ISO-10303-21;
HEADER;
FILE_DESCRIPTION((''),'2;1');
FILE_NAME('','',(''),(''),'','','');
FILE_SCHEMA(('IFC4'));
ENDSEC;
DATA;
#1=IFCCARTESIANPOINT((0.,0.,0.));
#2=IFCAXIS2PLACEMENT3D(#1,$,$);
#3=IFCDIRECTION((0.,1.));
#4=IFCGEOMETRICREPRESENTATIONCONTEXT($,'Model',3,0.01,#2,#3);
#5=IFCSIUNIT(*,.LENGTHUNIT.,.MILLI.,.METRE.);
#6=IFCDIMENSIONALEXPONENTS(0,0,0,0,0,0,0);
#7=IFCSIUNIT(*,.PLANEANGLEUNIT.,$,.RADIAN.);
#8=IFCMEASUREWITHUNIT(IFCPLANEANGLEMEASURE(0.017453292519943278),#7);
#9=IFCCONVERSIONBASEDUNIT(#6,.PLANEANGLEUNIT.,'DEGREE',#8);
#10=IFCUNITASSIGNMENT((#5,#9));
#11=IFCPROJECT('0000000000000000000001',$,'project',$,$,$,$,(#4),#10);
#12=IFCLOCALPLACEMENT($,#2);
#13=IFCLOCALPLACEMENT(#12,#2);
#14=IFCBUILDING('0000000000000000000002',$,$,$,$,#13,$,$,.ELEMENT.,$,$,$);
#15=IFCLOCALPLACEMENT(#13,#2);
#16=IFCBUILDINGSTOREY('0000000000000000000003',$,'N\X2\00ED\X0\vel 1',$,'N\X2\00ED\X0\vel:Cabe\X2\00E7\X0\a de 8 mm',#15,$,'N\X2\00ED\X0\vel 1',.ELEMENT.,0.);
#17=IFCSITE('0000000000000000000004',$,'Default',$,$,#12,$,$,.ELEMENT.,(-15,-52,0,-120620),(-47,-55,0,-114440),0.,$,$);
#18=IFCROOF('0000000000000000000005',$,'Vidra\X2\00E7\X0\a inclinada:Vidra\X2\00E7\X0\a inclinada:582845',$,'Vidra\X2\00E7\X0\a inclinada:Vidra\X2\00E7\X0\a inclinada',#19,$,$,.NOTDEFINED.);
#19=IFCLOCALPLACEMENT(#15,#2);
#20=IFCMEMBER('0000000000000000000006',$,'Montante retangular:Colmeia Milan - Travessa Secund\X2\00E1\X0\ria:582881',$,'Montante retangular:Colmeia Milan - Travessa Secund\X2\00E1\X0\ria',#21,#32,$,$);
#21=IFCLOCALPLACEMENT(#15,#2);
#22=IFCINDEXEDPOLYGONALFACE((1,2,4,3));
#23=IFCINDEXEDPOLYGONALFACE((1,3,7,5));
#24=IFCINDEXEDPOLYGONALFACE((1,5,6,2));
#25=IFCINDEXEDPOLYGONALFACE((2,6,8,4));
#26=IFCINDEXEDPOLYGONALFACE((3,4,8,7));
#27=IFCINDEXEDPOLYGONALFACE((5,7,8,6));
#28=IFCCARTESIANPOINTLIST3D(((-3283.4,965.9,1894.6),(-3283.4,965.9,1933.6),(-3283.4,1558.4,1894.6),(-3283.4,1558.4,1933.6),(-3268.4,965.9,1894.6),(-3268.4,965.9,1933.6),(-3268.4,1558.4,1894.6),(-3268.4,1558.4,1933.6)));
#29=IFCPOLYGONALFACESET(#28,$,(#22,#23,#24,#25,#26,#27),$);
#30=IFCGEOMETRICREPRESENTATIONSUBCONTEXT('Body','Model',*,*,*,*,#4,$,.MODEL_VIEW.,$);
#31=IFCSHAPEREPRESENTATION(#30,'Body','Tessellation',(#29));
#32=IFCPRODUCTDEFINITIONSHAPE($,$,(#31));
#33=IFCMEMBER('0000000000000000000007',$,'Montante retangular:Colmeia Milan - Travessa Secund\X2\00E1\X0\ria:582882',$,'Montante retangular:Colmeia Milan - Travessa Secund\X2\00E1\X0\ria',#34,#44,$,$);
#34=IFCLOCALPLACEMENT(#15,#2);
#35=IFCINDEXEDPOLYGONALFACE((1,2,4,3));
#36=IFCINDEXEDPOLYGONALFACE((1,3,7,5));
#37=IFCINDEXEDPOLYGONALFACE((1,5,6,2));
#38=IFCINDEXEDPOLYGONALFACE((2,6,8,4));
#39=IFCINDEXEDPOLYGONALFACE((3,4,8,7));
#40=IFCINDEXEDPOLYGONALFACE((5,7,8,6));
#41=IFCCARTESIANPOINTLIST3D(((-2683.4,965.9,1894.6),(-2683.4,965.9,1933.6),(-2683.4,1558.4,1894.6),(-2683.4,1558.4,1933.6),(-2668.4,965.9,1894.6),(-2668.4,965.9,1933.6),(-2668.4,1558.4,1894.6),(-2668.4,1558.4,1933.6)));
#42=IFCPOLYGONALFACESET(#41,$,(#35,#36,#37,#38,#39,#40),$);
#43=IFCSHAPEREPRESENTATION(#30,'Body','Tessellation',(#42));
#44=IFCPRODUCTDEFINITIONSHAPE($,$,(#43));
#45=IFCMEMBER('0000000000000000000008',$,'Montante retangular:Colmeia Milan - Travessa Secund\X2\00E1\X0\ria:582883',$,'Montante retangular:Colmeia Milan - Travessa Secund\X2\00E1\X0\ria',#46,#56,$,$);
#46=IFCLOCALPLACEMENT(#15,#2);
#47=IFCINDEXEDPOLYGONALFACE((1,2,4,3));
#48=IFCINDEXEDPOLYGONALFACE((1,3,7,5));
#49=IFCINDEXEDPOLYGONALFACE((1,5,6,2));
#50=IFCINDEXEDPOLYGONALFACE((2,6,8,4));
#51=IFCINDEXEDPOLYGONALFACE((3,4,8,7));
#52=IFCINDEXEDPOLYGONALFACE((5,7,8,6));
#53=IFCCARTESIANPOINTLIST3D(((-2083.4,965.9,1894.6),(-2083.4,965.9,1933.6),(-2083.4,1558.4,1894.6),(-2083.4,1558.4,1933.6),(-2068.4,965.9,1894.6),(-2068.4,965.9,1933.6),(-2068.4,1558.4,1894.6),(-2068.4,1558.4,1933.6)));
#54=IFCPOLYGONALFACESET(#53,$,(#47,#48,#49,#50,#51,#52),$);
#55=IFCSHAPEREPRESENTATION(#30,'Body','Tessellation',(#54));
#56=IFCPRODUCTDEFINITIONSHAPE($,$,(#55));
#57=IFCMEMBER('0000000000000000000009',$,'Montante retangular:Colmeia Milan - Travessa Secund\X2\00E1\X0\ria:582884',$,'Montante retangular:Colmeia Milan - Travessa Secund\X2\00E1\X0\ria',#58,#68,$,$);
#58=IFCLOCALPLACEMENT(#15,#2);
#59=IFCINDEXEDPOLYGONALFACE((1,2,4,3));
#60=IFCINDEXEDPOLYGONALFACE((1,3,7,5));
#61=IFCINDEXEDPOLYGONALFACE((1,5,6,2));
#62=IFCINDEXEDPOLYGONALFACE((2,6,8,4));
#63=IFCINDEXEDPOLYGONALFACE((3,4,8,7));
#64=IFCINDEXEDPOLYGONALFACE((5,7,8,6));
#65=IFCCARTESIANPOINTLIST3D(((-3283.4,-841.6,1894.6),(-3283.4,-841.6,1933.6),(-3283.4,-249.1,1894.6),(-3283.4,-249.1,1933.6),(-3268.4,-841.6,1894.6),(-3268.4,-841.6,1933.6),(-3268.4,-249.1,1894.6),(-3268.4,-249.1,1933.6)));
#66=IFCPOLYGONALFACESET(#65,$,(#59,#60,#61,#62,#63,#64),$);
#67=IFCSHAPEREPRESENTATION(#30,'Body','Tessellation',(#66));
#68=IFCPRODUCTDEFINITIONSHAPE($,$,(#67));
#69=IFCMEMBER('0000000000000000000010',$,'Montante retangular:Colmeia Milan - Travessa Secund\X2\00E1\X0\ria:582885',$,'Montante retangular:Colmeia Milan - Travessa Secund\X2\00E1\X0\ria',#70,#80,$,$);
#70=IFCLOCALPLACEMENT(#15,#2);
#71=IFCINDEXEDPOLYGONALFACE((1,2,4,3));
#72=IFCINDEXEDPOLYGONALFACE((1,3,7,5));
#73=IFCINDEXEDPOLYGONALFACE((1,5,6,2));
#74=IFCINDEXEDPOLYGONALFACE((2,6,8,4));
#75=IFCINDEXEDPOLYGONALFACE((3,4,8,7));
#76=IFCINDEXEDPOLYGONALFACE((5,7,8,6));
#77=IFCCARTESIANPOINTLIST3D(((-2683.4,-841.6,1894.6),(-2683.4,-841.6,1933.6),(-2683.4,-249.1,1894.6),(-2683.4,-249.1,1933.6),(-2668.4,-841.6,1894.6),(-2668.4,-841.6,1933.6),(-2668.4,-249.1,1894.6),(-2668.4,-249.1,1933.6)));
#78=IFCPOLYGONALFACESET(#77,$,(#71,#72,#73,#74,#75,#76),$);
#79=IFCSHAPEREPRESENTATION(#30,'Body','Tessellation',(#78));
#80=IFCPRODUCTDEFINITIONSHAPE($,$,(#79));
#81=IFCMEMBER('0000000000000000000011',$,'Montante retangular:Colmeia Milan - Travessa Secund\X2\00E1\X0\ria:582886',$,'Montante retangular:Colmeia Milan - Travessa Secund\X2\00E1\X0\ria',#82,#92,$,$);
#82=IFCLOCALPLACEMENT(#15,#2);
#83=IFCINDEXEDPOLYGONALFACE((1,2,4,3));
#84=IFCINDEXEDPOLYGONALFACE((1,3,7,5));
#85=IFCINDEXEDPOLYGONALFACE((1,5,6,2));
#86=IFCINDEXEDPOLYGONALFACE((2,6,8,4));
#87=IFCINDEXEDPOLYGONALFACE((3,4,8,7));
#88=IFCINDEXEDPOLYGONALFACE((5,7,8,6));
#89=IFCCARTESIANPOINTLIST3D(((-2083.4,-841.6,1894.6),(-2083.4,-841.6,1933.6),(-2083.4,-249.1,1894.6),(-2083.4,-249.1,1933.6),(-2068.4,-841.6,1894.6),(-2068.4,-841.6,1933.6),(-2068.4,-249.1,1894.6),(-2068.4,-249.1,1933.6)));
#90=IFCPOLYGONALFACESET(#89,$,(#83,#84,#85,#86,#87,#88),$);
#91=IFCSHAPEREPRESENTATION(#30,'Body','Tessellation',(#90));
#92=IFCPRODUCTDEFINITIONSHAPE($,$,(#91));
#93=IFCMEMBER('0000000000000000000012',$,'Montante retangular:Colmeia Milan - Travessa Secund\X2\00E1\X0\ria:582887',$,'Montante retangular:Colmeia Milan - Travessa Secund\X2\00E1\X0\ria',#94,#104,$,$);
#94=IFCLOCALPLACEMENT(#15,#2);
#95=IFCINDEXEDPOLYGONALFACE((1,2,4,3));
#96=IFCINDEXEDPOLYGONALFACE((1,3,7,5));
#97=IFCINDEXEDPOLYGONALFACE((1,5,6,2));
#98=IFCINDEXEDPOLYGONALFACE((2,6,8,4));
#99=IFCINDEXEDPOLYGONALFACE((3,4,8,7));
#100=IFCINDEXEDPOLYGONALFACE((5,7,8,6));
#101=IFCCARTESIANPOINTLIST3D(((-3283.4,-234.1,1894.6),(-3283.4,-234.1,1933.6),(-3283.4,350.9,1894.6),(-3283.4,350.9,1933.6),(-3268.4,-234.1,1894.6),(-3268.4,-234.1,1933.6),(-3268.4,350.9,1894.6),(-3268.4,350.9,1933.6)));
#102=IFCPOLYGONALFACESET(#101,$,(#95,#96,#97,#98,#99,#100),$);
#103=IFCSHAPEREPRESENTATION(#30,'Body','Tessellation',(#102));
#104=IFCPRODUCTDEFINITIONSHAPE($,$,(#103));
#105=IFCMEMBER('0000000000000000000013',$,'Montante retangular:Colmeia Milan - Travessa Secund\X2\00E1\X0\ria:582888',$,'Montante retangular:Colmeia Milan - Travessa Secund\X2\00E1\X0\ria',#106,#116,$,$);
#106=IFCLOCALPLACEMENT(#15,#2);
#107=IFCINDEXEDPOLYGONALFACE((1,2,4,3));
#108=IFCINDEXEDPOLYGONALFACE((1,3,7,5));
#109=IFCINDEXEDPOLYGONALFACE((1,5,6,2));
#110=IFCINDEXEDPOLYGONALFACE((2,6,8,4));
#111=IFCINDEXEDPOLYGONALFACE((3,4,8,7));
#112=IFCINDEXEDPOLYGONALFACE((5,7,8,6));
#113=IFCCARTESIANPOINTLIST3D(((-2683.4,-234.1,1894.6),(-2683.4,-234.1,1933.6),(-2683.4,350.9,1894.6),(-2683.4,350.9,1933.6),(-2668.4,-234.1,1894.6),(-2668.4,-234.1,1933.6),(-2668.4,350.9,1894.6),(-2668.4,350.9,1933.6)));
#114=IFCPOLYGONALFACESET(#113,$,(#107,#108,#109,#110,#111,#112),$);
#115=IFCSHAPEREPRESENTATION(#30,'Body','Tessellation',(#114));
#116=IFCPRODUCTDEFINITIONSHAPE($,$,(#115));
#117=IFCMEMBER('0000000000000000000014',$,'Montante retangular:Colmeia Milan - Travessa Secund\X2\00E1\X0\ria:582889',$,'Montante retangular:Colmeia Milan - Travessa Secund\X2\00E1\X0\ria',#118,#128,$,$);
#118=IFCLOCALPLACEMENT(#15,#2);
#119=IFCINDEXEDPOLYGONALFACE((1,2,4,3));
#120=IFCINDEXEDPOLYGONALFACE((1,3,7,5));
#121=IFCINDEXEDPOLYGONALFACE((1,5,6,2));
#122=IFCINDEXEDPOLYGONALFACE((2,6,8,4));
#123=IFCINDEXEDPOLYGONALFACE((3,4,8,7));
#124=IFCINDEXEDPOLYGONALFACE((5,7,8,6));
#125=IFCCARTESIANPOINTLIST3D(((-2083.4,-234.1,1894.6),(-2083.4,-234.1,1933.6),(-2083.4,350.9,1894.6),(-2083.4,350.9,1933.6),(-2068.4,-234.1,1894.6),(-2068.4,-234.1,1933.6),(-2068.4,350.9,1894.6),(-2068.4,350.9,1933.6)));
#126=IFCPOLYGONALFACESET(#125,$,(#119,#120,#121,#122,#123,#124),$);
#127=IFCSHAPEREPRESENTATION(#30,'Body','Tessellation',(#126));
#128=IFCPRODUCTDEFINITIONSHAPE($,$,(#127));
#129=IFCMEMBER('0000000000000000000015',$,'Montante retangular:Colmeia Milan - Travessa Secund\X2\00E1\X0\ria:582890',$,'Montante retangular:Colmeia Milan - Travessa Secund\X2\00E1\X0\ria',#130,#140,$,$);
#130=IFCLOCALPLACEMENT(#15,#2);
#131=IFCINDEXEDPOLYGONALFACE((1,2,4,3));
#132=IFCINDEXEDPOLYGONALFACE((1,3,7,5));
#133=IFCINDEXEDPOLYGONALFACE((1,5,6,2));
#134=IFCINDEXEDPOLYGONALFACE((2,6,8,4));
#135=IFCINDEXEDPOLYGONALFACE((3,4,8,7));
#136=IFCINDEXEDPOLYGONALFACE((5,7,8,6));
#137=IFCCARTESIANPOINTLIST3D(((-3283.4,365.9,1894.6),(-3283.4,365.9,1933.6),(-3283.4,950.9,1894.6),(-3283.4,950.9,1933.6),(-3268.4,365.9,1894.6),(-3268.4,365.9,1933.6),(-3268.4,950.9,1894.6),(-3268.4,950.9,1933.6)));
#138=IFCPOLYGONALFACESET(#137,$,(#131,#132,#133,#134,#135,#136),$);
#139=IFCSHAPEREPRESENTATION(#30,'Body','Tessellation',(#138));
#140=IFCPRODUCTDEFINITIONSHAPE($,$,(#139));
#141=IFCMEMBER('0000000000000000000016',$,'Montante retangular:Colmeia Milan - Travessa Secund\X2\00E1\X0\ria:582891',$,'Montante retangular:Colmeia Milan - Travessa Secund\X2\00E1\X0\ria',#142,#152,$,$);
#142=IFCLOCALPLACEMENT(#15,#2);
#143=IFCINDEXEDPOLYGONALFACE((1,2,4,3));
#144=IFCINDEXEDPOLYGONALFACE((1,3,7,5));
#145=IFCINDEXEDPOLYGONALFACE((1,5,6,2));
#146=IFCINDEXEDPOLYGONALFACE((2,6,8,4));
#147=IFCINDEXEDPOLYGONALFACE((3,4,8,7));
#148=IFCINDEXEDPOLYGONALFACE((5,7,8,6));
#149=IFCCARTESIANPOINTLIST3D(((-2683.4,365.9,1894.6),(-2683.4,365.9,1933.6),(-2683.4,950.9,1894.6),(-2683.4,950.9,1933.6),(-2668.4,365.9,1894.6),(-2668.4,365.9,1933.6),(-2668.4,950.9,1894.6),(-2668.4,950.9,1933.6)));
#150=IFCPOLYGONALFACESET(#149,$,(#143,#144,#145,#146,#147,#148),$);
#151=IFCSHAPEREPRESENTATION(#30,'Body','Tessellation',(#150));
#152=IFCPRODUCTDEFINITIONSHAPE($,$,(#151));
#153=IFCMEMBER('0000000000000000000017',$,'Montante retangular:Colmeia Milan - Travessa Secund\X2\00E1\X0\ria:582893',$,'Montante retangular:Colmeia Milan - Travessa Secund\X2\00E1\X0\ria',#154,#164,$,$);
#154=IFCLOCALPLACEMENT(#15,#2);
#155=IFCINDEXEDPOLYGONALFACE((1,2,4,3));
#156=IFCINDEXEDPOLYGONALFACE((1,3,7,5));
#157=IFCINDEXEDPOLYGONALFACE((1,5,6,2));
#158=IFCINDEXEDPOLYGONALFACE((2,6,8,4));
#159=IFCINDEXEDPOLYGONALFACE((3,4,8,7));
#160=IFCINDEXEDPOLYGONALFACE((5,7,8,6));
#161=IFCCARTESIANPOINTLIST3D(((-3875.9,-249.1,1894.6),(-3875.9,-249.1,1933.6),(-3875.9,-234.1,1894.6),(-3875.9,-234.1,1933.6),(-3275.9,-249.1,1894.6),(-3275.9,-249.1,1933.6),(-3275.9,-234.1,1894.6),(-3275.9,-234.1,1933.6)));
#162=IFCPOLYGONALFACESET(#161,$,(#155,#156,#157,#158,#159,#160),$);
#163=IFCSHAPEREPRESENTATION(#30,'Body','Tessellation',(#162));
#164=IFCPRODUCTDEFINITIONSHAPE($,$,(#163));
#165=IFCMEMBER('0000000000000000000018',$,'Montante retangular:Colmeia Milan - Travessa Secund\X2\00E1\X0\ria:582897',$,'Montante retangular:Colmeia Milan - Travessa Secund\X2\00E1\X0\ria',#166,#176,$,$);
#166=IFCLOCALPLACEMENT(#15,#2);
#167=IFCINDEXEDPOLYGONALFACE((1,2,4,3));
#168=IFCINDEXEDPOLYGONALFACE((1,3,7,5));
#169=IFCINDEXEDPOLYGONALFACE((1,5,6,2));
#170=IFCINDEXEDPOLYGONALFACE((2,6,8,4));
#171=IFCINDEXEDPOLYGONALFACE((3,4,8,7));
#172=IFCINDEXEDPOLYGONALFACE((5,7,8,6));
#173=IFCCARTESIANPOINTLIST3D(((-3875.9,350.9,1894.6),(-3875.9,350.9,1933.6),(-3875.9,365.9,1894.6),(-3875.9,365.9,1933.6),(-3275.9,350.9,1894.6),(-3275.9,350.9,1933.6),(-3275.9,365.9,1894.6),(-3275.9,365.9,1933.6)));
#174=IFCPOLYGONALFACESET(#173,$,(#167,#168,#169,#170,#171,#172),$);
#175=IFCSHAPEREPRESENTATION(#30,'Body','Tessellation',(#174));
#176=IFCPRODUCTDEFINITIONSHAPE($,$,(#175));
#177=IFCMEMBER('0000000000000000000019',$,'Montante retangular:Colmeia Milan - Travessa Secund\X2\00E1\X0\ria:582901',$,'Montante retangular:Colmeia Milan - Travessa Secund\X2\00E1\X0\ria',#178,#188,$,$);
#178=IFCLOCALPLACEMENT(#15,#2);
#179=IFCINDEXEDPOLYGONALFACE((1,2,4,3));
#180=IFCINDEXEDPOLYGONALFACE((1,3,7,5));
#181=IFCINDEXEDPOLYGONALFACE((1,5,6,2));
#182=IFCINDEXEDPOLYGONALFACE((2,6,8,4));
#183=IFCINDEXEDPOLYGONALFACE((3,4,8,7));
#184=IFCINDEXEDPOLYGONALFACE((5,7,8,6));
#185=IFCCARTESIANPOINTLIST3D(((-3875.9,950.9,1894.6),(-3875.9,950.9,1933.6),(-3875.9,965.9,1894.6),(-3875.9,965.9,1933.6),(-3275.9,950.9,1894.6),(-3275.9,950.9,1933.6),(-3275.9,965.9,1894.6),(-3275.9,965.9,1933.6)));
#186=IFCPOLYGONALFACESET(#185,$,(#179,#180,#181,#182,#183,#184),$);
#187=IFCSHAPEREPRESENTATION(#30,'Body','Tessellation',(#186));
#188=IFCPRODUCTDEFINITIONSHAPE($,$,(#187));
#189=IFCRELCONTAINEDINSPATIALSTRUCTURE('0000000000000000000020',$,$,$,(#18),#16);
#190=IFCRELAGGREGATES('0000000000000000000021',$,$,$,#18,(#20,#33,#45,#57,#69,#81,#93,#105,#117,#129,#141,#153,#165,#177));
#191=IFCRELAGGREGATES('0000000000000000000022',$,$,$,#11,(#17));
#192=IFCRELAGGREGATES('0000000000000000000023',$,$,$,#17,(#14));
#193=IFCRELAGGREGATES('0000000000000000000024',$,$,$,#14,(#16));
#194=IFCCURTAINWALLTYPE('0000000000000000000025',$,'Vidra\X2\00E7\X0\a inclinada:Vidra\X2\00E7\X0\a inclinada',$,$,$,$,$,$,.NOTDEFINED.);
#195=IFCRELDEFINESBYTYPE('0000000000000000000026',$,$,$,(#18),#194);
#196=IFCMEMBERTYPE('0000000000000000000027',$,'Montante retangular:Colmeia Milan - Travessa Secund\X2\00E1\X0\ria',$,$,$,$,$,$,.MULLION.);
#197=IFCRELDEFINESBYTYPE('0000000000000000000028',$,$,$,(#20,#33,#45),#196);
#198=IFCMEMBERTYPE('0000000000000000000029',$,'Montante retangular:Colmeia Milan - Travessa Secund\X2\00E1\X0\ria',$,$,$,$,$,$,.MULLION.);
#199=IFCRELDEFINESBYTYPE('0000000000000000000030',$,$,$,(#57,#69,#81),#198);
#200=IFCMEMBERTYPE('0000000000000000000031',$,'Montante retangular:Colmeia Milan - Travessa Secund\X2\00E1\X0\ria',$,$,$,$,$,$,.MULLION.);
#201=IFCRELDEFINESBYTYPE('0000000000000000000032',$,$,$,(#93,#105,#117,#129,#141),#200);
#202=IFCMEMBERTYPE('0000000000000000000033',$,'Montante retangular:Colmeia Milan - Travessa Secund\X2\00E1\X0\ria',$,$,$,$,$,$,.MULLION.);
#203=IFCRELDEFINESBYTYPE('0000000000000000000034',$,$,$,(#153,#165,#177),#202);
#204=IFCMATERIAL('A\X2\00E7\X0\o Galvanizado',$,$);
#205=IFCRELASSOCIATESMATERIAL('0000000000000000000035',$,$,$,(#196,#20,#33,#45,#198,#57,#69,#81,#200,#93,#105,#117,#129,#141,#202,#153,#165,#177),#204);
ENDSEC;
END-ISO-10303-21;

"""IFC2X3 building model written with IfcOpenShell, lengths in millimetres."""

from ifc_helpers import new_model, entity, si_unit, converted_unit, direction, frame, origin, origin_2d_with_axis, place, context, subcontext, project, spatial, rectangle, extrude, source, transform, mapped, material, type_object, type_shapes, element, aggregate, save


model = new_model("IFC2X3")

# Units and contexts
model_context = context("Model", 3, precision=0.01, world=origin(), true_north=direction((0.0, 1.0)))
body_context = subcontext(model_context, "Body", "Model", "MODEL_VIEW")
ifc_project = project(units=[si_unit("LENGTHUNIT", "METRE", prefix="MILLI"), converted_unit("PLANEANGLEUNIT", "DEGREE", entity("IfcPlaneAngleMeasure", 0.017453292519943278), si_unit("PLANEANGLEUNIT", "RADIAN"), dimensions=[0, 0, 0, 0, 0, 0, 0])], contexts=[model_context])

# Site, building, storey
site_placement = place(None, origin())
site = spatial("IfcSite", under=ifc_project, at=site_placement, Name="Default", CompositionType="ELEMENT", RefLatitude=(-15, -52, 0, -120620), RefLongitude=(-47, -55, 0, -114440), RefElevation=0.0)
building_placement = place(site_placement, origin())
building = spatial("IfcBuilding", under=site, at=building_placement, CompositionType="ELEMENT")
storey_placement = place(building_placement, origin())
storey = spatial("IfcBuildingStorey", under=building, at=storey_placement, Name="Nível 1", ObjectType="Nível:Cabeça de 8 mm", LongName="Nível 1", CompositionType="ELEMENT", Elevation=0.0)

# Roof, members
curtain_wall_type = type_object("IfcCurtainWallType", Name="Vidraça inclinada:Vidraça inclinada", PredefinedType="NOTDEFINED")
roof_placement = place(storey_placement, origin())
roof = element("IfcRoof", 1, at=roof_placement, inside=storey, type_object=curtain_wall_type, Name="Vidraça inclinada:Vidraça inclinada:582845", ObjectType="Vidraça inclinada:Vidraça inclinada", ShapeType="NOTDEFINED")
ifc_material_1 = material(Name="Aço Galvanizado")
member_type_1 = type_object("IfcMemberType", Name="Montante retangular:Colmeia Milan - Travessa Secundária", PredefinedType="MULLION", material=ifc_material_1)
shared_shape_1 = source(origin(), body_context, "Body", "SweptSolid", [
    extrude(rectangle(XDim=15.0, YDim=39.0, at=origin_2d_with_axis()), frame((0.0, -19.5, -592.5), z_axis=(0.0, 0.0, 1.0), x_axis=(-1.0, 0.0, 0.0)), (0.0, 0.0, 1.0), 592.5),
])
type_shapes(member_type_1, [shared_shape_1])
member_1_placement = place(roof_placement, frame((-3275.9, 1558.4, 1894.6), z_axis=(0.0, 1.0, 0.0), x_axis=(1.0, 0.0, 0.0)))
member_1 = element("IfcMember", 2, at=member_1_placement, type_object=member_type_1, material=ifc_material_1, Name="Montante retangular:Colmeia Milan - Travessa Secundária:582881", ObjectType="Montante retangular:Colmeia Milan - Travessa Secundária", context=body_context, shape_type="MappedRepresentation", body=[
    mapped(shared_shape_1, transform((0.0, 0.0, 0.0), scale=1.0)),
])
member_2_placement = place(roof_placement, frame((-2675.9, 1558.4, 1894.6), z_axis=(0.0, 1.0, 0.0), x_axis=(1.0, 0.0, 0.0)))
member_2 = element("IfcMember", 3, at=member_2_placement, type_object=member_type_1, material=ifc_material_1, Name="Montante retangular:Colmeia Milan - Travessa Secundária:582882", ObjectType="Montante retangular:Colmeia Milan - Travessa Secundária", context=body_context, shape_type="MappedRepresentation", body=[
    mapped(shared_shape_1, transform((0.0, 0.0, 0.0), scale=1.0)),
])
member_3_placement = place(roof_placement, frame((-2075.9, 1558.4, 1894.6), z_axis=(0.0, 1.0, 0.0), x_axis=(1.0, 0.0, 0.0)))
member_3 = element("IfcMember", 4, at=member_3_placement, type_object=member_type_1, material=ifc_material_1, Name="Montante retangular:Colmeia Milan - Travessa Secundária:582883", ObjectType="Montante retangular:Colmeia Milan - Travessa Secundária", context=body_context, shape_type="MappedRepresentation", body=[
    mapped(shared_shape_1, transform((0.0, 0.0, 0.0), scale=1.0)),
])
member_type_2 = type_object("IfcMemberType", Name="Montante retangular:Colmeia Milan - Travessa Secundária", PredefinedType="MULLION", material=ifc_material_1)
shared_shape_2 = source(origin(), body_context, "Body", "SweptSolid", [
    extrude(rectangle(XDim=15.0, YDim=39.0, at=origin_2d_with_axis()), frame((0.0, -19.5, -592.5), z_axis=(0.0, 0.0, 1.0), x_axis=(-1.0, 0.0, 0.0)), (0.0, 0.0, 1.0), 592.5),
])
type_shapes(member_type_2, [shared_shape_2])
member_4_placement = place(roof_placement, frame((-3275.9, -249.1, 1894.6), z_axis=(0.0, 1.0, 0.0), x_axis=(1.0, 0.0, 0.0)))
member_4 = element("IfcMember", 5, at=member_4_placement, type_object=member_type_2, material=ifc_material_1, Name="Montante retangular:Colmeia Milan - Travessa Secundária:582884", ObjectType="Montante retangular:Colmeia Milan - Travessa Secundária", context=body_context, shape_type="MappedRepresentation", body=[
    mapped(shared_shape_2, transform((0.0, 0.0, 0.0), scale=1.0)),
])
member_5_placement = place(roof_placement, frame((-2675.9, -249.1, 1894.6), z_axis=(0.0, 1.0, 0.0), x_axis=(1.0, 0.0, 0.0)))
member_5 = element("IfcMember", 6, at=member_5_placement, type_object=member_type_2, material=ifc_material_1, Name="Montante retangular:Colmeia Milan - Travessa Secundária:582885", ObjectType="Montante retangular:Colmeia Milan - Travessa Secundária", context=body_context, shape_type="MappedRepresentation", body=[
    mapped(shared_shape_2, transform((0.0, 0.0, 0.0), scale=1.0)),
])
member_6_placement = place(roof_placement, frame((-2075.9, -249.1, 1894.6), z_axis=(0.0, 1.0, 0.0), x_axis=(1.0, 0.0, 0.0)))
member_6 = element("IfcMember", 7, at=member_6_placement, type_object=member_type_2, material=ifc_material_1, Name="Montante retangular:Colmeia Milan - Travessa Secundária:582886", ObjectType="Montante retangular:Colmeia Milan - Travessa Secundária", context=body_context, shape_type="MappedRepresentation", body=[
    mapped(shared_shape_2, transform((0.0, 0.0, 0.0), scale=1.0)),
])
member_type_3 = type_object("IfcMemberType", Name="Montante retangular:Colmeia Milan - Travessa Secundária", PredefinedType="MULLION", material=ifc_material_1)
shared_shape_3 = source(origin(), body_context, "Body", "SweptSolid", [
    extrude(rectangle(XDim=15.0, YDim=39.0, at=origin_2d_with_axis()), frame((0.0, -19.5, -585.0), z_axis=(0.0, 0.0, 1.0), x_axis=(-1.0, 0.0, 0.0)), (0.0, 0.0, 1.0), 585.0),
])
type_shapes(member_type_3, [shared_shape_3])
member_7_placement = place(roof_placement, frame((-3275.9, 350.9, 1894.6), z_axis=(0.0, 1.0, 0.0), x_axis=(1.0, 0.0, 0.0)))
member_7 = element("IfcMember", 8, at=member_7_placement, type_object=member_type_3, material=ifc_material_1, Name="Montante retangular:Colmeia Milan - Travessa Secundária:582887", ObjectType="Montante retangular:Colmeia Milan - Travessa Secundária", context=body_context, shape_type="MappedRepresentation", body=[
    mapped(shared_shape_3, transform((0.0, 0.0, 0.0), scale=1.0)),
])
member_8_placement = place(roof_placement, frame((-2675.9, 350.9, 1894.6), z_axis=(0.0, 1.0, 0.0), x_axis=(1.0, 0.0, 0.0)))
member_8 = element("IfcMember", 9, at=member_8_placement, type_object=member_type_3, material=ifc_material_1, Name="Montante retangular:Colmeia Milan - Travessa Secundária:582888", ObjectType="Montante retangular:Colmeia Milan - Travessa Secundária", context=body_context, shape_type="MappedRepresentation", body=[
    mapped(shared_shape_3, transform((0.0, 0.0, 0.0), scale=1.0)),
])
member_9_placement = place(roof_placement, frame((-2075.9, 350.9, 1894.6), z_axis=(0.0, 1.0, 0.0), x_axis=(1.0, 0.0, 0.0)))
member_9 = element("IfcMember", 10, at=member_9_placement, type_object=member_type_3, material=ifc_material_1, Name="Montante retangular:Colmeia Milan - Travessa Secundária:582889", ObjectType="Montante retangular:Colmeia Milan - Travessa Secundária", context=body_context, shape_type="MappedRepresentation", body=[
    mapped(shared_shape_3, transform((0.0, 0.0, 0.0), scale=1.0)),
])
member_10_placement = place(roof_placement, frame((-3275.9, 950.9, 1894.6), z_axis=(0.0, 1.0, 0.0), x_axis=(1.0, 0.0, 0.0)))
member_10 = element("IfcMember", 11, at=member_10_placement, type_object=member_type_3, material=ifc_material_1, Name="Montante retangular:Colmeia Milan - Travessa Secundária:582890", ObjectType="Montante retangular:Colmeia Milan - Travessa Secundária", context=body_context, shape_type="MappedRepresentation", body=[
    mapped(shared_shape_3, transform((0.0, 0.0, 0.0), scale=1.0)),
])
member_11_placement = place(roof_placement, frame((-2675.9, 950.9, 1894.6), z_axis=(0.0, 1.0, 0.0), x_axis=(1.0, 0.0, 0.0)))
member_11 = element("IfcMember", 12, at=member_11_placement, type_object=member_type_3, material=ifc_material_1, Name="Montante retangular:Colmeia Milan - Travessa Secundária:582891", ObjectType="Montante retangular:Colmeia Milan - Travessa Secundária", context=body_context, shape_type="MappedRepresentation", body=[
    mapped(shared_shape_3, transform((0.0, 0.0, 0.0), scale=1.0)),
])
member_type_4 = type_object("IfcMemberType", Name="Montante retangular:Colmeia Milan - Travessa Secundária", PredefinedType="MULLION", material=ifc_material_1)
shared_shape_4 = source(origin(), body_context, "Body", "SweptSolid", [
    extrude(rectangle(XDim=15.0, YDim=39.0, at=origin_2d_with_axis()), frame((0.0, -19.5, -600.0), z_axis=(0.0, 0.0, 1.0), x_axis=(-1.0, 0.0, 0.0)), (0.0, 0.0, 1.0), 600.0),
])
type_shapes(member_type_4, [shared_shape_4])
member_12_placement = place(roof_placement, frame((-3875.9, -241.6, 1894.6), z_axis=(-1.0, 0.0, 0.0), x_axis=(0.0, 1.0, 0.0)))
member_12 = element("IfcMember", 13, at=member_12_placement, type_object=member_type_4, material=ifc_material_1, Name="Montante retangular:Colmeia Milan - Travessa Secundária:582893", ObjectType="Montante retangular:Colmeia Milan - Travessa Secundária", context=body_context, shape_type="MappedRepresentation", body=[
    mapped(shared_shape_4, transform((0.0, 0.0, 0.0), scale=1.0)),
])
member_13_placement = place(roof_placement, frame((-3875.9, 358.4, 1894.6), z_axis=(-1.0, 0.0, 0.0), x_axis=(0.0, 1.0, 0.0)))
member_13 = element("IfcMember", 14, at=member_13_placement, type_object=member_type_4, material=ifc_material_1, Name="Montante retangular:Colmeia Milan - Travessa Secundária:582897", ObjectType="Montante retangular:Colmeia Milan - Travessa Secundária", context=body_context, shape_type="MappedRepresentation", body=[
    mapped(shared_shape_4, transform((0.0, 0.0, 0.0), scale=1.0)),
])
member_14_placement = place(roof_placement, frame((-3875.9, 958.4, 1894.6), z_axis=(-1.0, 0.0, 0.0), x_axis=(0.0, 1.0, 0.0)))
member_14 = element("IfcMember", 15, at=member_14_placement, type_object=member_type_4, material=ifc_material_1, Name="Montante retangular:Colmeia Milan - Travessa Secundária:582901", ObjectType="Montante retangular:Colmeia Milan - Travessa Secundária", context=body_context, shape_type="MappedRepresentation", body=[
    mapped(shared_shape_4, transform((0.0, 0.0, 0.0), scale=1.0)),
])
aggregate(roof, [member_1, member_2, member_3, member_4, member_5, member_6, member_7, member_8, member_9, member_10, member_11, member_12, member_13, member_14])

save(model, "model.ifc")
